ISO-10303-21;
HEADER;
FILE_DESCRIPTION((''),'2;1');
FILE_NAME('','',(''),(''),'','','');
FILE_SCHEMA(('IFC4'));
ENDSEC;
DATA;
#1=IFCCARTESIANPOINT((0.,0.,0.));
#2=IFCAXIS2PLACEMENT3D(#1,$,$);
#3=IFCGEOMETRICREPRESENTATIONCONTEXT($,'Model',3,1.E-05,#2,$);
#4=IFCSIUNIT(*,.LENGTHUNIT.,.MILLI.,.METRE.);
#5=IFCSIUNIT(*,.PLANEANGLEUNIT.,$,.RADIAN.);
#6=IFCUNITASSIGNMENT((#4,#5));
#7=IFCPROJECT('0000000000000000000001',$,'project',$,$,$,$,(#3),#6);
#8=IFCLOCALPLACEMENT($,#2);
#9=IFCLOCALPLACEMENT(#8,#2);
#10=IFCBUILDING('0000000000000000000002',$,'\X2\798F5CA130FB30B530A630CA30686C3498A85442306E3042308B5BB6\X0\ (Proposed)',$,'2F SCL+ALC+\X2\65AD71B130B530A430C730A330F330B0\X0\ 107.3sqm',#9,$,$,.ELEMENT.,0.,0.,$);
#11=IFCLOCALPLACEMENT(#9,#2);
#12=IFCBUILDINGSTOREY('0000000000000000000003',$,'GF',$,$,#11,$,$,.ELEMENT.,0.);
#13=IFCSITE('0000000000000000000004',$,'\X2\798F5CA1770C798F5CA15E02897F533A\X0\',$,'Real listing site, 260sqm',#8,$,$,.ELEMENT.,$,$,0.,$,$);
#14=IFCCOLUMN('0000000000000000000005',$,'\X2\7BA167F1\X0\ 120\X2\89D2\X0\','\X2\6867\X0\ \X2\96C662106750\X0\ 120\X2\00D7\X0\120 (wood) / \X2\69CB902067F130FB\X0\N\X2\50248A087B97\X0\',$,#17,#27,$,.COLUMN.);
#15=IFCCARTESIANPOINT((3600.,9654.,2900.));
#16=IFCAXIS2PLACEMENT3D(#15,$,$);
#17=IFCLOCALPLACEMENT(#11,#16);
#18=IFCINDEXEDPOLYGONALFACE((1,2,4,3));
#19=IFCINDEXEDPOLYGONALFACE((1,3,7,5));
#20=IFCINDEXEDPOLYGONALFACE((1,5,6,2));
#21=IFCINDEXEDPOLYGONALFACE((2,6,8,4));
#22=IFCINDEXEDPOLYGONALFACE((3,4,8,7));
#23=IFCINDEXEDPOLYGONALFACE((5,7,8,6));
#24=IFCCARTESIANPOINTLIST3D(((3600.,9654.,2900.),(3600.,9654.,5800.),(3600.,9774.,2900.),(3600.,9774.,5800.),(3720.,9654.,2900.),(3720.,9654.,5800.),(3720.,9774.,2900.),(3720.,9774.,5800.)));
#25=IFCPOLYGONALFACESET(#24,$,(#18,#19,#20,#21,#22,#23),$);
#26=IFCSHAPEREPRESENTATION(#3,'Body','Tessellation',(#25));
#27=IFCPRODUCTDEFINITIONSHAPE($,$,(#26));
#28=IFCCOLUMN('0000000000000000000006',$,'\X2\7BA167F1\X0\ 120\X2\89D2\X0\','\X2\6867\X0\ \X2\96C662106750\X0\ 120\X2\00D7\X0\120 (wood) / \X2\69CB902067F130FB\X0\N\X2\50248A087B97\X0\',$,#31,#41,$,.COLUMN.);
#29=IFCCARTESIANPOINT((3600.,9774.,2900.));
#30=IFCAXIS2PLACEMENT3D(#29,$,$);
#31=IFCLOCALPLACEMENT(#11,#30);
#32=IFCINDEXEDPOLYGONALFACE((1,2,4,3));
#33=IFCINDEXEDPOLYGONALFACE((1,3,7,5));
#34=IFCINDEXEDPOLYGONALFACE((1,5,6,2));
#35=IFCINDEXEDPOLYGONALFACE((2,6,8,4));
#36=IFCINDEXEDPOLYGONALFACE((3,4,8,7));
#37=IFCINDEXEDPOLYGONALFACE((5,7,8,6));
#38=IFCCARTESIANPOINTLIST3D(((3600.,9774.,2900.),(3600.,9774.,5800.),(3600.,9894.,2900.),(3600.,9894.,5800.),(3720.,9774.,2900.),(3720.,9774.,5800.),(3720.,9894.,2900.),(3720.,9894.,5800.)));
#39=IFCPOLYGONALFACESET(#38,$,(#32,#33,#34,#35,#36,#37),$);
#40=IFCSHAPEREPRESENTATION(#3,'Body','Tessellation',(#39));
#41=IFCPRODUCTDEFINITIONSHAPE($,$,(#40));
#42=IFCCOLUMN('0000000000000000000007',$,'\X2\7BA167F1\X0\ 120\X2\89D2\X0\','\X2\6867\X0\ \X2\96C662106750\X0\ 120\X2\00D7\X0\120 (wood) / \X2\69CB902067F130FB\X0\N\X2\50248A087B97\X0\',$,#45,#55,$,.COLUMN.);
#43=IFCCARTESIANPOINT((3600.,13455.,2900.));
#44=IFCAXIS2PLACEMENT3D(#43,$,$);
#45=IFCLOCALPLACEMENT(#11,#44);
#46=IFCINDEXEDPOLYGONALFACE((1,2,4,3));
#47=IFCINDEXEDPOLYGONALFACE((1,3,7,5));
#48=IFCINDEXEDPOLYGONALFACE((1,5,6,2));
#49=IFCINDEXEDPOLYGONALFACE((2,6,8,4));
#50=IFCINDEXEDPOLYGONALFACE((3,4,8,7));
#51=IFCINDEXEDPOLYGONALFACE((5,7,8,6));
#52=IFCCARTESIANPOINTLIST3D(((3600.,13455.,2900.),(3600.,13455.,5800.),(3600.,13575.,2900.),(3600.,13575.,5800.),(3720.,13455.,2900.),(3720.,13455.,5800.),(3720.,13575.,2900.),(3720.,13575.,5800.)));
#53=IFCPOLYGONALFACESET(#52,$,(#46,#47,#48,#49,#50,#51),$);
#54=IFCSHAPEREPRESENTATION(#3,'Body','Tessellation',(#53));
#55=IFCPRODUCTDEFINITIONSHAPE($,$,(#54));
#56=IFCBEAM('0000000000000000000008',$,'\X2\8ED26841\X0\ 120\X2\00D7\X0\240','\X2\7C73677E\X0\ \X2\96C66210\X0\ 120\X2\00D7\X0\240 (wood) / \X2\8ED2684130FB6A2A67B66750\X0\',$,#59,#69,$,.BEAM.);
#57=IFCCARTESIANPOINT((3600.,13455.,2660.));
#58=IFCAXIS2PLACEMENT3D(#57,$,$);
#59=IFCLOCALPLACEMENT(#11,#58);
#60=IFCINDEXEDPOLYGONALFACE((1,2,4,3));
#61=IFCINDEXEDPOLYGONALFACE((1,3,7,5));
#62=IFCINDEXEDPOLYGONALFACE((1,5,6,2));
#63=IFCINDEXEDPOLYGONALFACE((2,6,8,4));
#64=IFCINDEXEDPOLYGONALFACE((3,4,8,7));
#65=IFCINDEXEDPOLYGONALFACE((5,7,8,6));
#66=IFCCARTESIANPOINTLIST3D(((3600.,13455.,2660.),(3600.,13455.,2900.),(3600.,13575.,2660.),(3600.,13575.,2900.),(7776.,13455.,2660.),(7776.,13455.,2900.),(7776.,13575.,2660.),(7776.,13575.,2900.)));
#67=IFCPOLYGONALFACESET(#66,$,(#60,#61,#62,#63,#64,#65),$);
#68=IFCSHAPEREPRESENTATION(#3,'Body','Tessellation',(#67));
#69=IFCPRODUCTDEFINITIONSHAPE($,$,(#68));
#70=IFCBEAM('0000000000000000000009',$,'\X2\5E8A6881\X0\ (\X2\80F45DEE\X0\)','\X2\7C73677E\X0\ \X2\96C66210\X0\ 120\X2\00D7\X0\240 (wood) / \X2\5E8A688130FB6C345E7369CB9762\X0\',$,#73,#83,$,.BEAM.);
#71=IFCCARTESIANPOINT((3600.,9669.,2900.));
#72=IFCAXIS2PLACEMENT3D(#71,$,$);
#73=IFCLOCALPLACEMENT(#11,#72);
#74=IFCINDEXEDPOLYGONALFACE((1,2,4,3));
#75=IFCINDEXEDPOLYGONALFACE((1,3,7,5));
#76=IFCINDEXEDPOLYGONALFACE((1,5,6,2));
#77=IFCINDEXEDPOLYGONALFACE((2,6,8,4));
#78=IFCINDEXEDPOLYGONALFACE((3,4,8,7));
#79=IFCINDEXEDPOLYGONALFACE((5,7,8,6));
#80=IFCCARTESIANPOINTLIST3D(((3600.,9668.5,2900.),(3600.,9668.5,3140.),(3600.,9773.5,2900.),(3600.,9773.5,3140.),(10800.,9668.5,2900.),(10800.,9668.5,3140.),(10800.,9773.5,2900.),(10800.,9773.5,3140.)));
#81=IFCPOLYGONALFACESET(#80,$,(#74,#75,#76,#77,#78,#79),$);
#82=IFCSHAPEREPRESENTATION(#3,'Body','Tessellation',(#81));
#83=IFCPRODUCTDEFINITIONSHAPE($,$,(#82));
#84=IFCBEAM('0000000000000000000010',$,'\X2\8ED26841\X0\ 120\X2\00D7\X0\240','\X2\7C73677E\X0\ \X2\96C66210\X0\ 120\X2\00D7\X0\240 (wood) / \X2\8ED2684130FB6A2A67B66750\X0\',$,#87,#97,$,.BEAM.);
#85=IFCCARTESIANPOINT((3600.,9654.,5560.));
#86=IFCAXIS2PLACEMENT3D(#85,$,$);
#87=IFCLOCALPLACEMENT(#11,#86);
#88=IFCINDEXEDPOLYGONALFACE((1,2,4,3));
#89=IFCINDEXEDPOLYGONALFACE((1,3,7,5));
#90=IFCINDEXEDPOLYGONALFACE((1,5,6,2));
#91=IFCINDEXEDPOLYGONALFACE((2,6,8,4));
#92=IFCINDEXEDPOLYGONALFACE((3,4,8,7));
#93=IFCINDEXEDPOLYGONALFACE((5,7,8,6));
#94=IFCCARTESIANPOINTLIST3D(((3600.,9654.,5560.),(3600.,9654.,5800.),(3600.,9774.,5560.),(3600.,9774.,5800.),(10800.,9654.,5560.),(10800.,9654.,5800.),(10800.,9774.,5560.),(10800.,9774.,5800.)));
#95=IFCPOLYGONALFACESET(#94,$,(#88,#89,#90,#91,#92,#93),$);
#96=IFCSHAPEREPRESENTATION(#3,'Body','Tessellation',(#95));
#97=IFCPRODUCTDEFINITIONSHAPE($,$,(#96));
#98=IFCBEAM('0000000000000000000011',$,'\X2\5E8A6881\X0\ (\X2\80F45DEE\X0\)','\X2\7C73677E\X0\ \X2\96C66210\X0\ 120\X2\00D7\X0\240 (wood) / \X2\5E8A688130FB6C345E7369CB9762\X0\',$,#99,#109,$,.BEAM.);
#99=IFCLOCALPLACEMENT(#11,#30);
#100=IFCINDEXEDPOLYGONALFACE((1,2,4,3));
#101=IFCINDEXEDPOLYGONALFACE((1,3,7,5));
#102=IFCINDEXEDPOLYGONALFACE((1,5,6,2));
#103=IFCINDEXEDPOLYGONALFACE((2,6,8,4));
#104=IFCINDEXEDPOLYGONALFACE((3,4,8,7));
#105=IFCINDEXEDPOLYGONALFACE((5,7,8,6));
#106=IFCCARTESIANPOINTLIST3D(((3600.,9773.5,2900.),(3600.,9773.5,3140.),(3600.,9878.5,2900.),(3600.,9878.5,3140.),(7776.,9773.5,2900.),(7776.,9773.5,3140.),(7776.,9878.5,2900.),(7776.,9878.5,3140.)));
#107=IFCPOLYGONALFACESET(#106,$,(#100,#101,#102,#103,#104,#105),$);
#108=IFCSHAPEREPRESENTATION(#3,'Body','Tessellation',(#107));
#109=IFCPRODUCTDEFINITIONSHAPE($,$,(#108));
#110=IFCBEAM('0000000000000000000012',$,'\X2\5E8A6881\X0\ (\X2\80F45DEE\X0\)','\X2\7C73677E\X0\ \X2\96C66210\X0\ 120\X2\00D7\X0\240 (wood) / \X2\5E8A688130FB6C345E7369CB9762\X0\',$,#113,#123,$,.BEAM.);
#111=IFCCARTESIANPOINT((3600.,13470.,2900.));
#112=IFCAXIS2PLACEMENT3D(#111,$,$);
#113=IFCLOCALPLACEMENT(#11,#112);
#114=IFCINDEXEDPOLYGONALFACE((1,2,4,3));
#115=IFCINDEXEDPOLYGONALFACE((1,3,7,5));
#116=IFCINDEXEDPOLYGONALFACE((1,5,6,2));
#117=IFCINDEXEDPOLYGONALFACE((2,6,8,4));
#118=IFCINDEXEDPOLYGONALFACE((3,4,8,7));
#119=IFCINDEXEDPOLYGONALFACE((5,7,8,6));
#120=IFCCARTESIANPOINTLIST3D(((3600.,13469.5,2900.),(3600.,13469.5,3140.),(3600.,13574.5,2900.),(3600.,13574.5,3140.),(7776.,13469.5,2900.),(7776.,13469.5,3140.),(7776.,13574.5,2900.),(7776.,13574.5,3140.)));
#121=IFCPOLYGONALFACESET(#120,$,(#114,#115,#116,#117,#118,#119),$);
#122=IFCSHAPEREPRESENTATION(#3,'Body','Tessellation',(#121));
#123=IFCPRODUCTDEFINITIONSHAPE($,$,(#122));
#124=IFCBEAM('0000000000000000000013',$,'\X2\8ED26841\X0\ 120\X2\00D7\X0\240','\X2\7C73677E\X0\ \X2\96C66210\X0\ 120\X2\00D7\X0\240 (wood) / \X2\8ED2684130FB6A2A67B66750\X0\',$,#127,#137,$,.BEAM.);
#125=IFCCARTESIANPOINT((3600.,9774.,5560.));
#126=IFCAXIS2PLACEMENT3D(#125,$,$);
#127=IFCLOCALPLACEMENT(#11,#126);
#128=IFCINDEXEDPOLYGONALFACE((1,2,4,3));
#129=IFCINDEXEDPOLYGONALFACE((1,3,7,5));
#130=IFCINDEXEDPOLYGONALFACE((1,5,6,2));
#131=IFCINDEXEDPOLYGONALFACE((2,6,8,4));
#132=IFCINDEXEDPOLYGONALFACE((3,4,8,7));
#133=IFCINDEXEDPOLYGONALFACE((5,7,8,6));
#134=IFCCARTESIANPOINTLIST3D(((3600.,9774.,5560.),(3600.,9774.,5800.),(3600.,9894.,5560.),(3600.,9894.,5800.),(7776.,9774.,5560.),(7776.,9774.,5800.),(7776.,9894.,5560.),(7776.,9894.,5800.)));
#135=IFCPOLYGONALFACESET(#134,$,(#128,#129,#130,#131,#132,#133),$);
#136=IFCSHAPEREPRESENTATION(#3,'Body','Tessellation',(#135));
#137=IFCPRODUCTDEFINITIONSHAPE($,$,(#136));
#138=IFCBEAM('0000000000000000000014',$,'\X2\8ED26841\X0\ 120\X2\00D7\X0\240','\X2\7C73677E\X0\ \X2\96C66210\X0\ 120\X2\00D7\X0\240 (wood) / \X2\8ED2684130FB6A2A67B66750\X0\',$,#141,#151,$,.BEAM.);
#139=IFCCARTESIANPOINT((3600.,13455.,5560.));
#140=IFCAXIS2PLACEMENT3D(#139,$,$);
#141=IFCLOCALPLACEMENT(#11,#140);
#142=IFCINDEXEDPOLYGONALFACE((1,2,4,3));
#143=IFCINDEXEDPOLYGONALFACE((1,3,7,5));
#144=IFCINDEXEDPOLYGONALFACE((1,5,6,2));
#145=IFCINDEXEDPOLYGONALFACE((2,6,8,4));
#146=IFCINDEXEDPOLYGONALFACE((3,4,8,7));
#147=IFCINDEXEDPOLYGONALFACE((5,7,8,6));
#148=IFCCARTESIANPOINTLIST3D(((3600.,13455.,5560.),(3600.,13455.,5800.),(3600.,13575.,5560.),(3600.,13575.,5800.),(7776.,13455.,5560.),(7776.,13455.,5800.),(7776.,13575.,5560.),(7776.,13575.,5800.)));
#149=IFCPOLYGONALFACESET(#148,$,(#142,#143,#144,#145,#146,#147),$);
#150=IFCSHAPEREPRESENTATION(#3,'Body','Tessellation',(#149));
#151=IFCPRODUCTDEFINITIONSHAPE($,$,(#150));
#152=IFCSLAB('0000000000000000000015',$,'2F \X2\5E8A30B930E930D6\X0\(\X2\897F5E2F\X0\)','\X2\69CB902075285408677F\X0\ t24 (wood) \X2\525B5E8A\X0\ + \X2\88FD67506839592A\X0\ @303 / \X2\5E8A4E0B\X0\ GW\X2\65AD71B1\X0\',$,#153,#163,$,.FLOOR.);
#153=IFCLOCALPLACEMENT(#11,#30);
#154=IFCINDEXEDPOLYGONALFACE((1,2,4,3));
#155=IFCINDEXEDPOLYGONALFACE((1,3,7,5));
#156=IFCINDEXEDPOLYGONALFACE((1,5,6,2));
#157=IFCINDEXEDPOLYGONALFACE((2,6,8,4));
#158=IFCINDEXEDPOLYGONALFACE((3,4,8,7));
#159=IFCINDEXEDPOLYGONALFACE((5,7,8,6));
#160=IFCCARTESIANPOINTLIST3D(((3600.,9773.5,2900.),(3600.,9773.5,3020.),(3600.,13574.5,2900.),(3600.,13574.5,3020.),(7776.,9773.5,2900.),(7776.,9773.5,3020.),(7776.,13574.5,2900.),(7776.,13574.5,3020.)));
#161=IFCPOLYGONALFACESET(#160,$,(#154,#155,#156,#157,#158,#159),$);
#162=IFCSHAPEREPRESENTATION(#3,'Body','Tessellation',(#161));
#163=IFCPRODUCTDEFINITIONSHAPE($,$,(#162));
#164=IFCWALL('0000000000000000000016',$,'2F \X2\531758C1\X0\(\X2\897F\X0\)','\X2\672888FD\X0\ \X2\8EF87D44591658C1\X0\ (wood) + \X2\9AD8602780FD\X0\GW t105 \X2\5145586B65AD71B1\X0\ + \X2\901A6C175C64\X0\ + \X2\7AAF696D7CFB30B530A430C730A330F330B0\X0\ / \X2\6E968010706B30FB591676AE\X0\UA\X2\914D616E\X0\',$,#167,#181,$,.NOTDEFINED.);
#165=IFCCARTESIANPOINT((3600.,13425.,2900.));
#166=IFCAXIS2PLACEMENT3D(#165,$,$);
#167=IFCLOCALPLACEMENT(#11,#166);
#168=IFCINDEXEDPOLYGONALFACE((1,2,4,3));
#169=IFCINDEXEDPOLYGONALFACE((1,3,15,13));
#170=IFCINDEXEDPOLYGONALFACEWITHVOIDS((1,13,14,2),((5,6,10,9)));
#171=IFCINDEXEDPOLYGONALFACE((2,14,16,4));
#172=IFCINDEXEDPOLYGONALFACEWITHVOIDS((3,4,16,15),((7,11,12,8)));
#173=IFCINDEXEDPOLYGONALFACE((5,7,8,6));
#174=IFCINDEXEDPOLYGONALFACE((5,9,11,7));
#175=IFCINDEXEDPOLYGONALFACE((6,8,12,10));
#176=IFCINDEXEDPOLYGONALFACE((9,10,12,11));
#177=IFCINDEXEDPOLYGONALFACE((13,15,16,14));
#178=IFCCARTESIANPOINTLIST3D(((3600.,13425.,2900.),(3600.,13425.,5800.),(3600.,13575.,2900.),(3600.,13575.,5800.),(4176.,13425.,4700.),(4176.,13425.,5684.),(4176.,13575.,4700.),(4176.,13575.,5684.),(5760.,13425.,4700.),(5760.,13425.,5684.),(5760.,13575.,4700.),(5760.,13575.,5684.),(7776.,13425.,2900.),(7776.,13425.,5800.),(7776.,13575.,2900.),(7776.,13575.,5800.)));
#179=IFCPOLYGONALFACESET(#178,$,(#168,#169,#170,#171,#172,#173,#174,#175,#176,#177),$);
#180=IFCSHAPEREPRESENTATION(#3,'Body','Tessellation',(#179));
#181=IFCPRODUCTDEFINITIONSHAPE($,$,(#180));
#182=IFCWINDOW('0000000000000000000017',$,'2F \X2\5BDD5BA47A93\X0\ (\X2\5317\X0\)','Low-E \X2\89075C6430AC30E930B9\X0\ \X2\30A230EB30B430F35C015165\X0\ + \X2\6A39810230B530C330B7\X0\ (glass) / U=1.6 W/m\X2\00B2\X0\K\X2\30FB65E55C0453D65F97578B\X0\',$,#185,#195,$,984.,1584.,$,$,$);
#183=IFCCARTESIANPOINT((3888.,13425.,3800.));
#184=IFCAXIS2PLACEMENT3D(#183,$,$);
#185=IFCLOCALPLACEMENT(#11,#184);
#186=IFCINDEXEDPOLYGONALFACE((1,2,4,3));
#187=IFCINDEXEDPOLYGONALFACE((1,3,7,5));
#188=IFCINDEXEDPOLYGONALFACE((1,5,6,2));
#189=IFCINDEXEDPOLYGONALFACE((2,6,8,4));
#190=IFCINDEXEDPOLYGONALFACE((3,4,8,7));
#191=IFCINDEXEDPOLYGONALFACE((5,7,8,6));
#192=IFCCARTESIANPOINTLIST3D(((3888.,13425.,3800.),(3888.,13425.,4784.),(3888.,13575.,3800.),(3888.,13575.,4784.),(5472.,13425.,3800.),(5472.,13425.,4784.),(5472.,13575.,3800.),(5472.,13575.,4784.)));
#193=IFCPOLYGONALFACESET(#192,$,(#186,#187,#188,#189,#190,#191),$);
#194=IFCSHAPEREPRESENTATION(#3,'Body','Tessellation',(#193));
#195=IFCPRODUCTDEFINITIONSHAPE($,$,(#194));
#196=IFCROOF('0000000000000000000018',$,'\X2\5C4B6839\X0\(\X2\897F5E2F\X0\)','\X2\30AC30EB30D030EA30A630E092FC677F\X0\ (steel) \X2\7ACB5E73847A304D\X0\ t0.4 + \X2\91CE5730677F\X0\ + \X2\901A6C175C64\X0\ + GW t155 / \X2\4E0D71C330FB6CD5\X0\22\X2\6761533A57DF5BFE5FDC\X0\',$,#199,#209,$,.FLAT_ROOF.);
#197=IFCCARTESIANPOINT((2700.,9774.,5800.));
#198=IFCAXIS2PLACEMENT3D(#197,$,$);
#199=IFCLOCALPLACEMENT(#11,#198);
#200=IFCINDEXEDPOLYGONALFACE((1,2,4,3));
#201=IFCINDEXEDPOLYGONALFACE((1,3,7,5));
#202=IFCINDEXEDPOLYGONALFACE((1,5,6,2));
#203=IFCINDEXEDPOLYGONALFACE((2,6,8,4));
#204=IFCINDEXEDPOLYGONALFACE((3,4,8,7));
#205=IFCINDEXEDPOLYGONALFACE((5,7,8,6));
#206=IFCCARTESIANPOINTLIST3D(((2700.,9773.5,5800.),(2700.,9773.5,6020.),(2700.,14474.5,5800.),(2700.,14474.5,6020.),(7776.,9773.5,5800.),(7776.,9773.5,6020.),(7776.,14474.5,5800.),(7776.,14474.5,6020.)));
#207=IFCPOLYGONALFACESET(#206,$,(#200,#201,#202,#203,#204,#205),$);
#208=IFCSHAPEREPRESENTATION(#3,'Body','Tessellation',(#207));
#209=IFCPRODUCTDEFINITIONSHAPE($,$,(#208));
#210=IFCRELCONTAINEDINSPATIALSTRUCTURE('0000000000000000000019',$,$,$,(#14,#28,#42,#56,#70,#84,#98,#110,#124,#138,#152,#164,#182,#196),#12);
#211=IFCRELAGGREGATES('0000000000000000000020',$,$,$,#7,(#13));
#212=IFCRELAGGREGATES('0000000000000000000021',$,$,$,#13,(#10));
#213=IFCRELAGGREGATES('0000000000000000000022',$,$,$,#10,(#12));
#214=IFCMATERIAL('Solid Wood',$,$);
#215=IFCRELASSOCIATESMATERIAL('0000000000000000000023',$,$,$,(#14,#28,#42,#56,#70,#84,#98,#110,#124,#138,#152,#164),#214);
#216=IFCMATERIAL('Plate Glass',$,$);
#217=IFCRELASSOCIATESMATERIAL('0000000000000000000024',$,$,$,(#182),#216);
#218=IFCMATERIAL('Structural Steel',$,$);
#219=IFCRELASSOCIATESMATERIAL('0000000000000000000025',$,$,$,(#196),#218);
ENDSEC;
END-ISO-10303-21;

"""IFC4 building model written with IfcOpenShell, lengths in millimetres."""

from ifc_helpers import new_model, si_unit, frame, frame_2d, origin, place, context, project, spatial, rectangle, extrude, material, element, fill, save


model = new_model("IFC4")

# Units and contexts
model_context = context("Model", 3, precision=1e-05, world=origin())
ifc_project = project(units=[si_unit("LENGTHUNIT", "METRE", prefix="MILLI"), si_unit("PLANEANGLEUNIT", "RADIAN")], contexts=[model_context])

# Site, building, storey
site_placement = place(None, origin())
site = spatial("IfcSite", under=ifc_project, at=site_placement, Name="福岡県福岡市西区", ObjectType="Real listing site, 260sqm", CompositionType="ELEMENT", RefElevation=0.0)
building_placement = place(site_placement, origin())
building = spatial("IfcBuilding", under=site, at=building_placement, Name="福岡・サウナと水風呂のある家 (Proposed)", ObjectType="2F SCL+ALC+断熱サイディング 107.3sqm", CompositionType="ELEMENT", ElevationOfRefHeight=0.0, ElevationOfTerrain=0.0)
storey_placement = place(building_placement, origin())
storey = spatial("IfcBuildingStorey", under=building, at=storey_placement, Name="GF", CompositionType="ELEMENT", Elevation=0.0)

# Columns
ifc_material_1 = material(Name="Solid Wood")
column_1_placement = place(storey_placement, frame((3600.0, 9654.0, 2900.0)))
element("IfcColumn", 1, at=column_1_placement, inside=storey, material=ifc_material_1, Name="管柱 120角", Description="桧 集成材 120×120 (wood) / 構造柱・N値計算", PredefinedType="COLUMN", context=model_context, shape_type="SweptSolid", body=[
    extrude(rectangle(XDim=120.0, YDim=120.0, at=frame_2d((60.0, 60.0))), frame((3600.0, 9654.0, 2900.0)), (0.0, 0.0, 1.0), 2900.0),
])
column_2_placement = place(storey_placement, frame((3600.0, 9774.0, 2900.0)))
element("IfcColumn", 2, at=column_2_placement, inside=storey, material=ifc_material_1, Name="管柱 120角", Description="桧 集成材 120×120 (wood) / 構造柱・N値計算", PredefinedType="COLUMN", context=model_context, shape_type="SweptSolid", body=[
    extrude(rectangle(XDim=120.0, YDim=120.0, at=frame_2d((60.0, 60.0))), frame((3600.0, 9774.0, 2900.0)), (0.0, 0.0, 1.0), 2900.0),
])
column_3_placement = place(storey_placement, frame((3600.0, 13455.0, 2900.0)))
element("IfcColumn", 3, at=column_3_placement, inside=storey, material=ifc_material_1, Name="管柱 120角", Description="桧 集成材 120×120 (wood) / 構造柱・N値計算", PredefinedType="COLUMN", context=model_context, shape_type="SweptSolid", body=[
    extrude(rectangle(XDim=120.0, YDim=120.0, at=frame_2d((60.0, 60.0))), frame((3600.0, 13455.0, 2900.0)), (0.0, 0.0, 1.0), 2900.0),
])

# Beams
beam_1_placement = place(storey_placement, frame((3600.0, 13455.0, 2660.0)))
element("IfcBeam", 4, at=beam_1_placement, inside=storey, material=ifc_material_1, Name="軒桁 120×240", Description="米松 集成 120×240 (wood) / 軒桁・横架材", PredefinedType="BEAM", context=model_context, shape_type="SweptSolid", body=[
    extrude(rectangle(XDim=4176.0, YDim=120.0, at=frame_2d((2088.0, 60.0))), frame((3600.0, 13455.0, 2660.0)), (0.0, 0.0, 1.0), 240.0),
])
beam_2_placement = place(storey_placement, frame((3600.0, 9669.0, 2900.0)))
element("IfcBeam", 5, at=beam_2_placement, inside=storey, material=ifc_material_1, Name="床梁 (胴差)", Description="米松 集成 120×240 (wood) / 床梁・水平構面", PredefinedType="BEAM", context=model_context, shape_type="SweptSolid", body=[
    extrude(rectangle(XDim=7200.0, YDim=105.0, at=frame_2d((3600.0, 52.0))), frame((3600.0, 9669.0, 2900.0)), (0.0, 0.0, 1.0), 240.0),
])
beam_3_placement = place(storey_placement, frame((3600.0, 9654.0, 5560.0)))
element("IfcBeam", 6, at=beam_3_placement, inside=storey, material=ifc_material_1, Name="軒桁 120×240", Description="米松 集成 120×240 (wood) / 軒桁・横架材", PredefinedType="BEAM", context=model_context, shape_type="SweptSolid", body=[
    extrude(rectangle(XDim=7200.0, YDim=120.0, at=frame_2d((3600.0, 60.0))), frame((3600.0, 9654.0, 5560.0)), (0.0, 0.0, 1.0), 240.0),
])
beam_4_placement = place(storey_placement, frame((3600.0, 9774.0, 2900.0)))
element("IfcBeam", 7, at=beam_4_placement, inside=storey, material=ifc_material_1, Name="床梁 (胴差)", Description="米松 集成 120×240 (wood) / 床梁・水平構面", PredefinedType="BEAM", context=model_context, shape_type="SweptSolid", body=[
    extrude(rectangle(XDim=4176.0, YDim=105.0, at=frame_2d((2088.0, 52.0))), frame((3600.0, 9774.0, 2900.0)), (0.0, 0.0, 1.0), 240.0),
])
beam_5_placement = place(storey_placement, frame((3600.0, 13470.0, 2900.0)))
element("IfcBeam", 8, at=beam_5_placement, inside=storey, material=ifc_material_1, Name="床梁 (胴差)", Description="米松 集成 120×240 (wood) / 床梁・水平構面", PredefinedType="BEAM", context=model_context, shape_type="SweptSolid", body=[
    extrude(rectangle(XDim=4176.0, YDim=105.0, at=frame_2d((2088.0, 52.0))), frame((3600.0, 13470.0, 2900.0)), (0.0, 0.0, 1.0), 240.0),
])
beam_6_placement = place(storey_placement, frame((3600.0, 9774.0, 5560.0)))
element("IfcBeam", 9, at=beam_6_placement, inside=storey, material=ifc_material_1, Name="軒桁 120×240", Description="米松 集成 120×240 (wood) / 軒桁・横架材", PredefinedType="BEAM", context=model_context, shape_type="SweptSolid", body=[
    extrude(rectangle(XDim=4176.0, YDim=120.0, at=frame_2d((2088.0, 60.0))), frame((3600.0, 9774.0, 5560.0)), (0.0, 0.0, 1.0), 240.0),
])
beam_7_placement = place(storey_placement, frame((3600.0, 13455.0, 5560.0)))
element("IfcBeam", 10, at=beam_7_placement, inside=storey, material=ifc_material_1, Name="軒桁 120×240", Description="米松 集成 120×240 (wood) / 軒桁・横架材", PredefinedType="BEAM", context=model_context, shape_type="SweptSolid", body=[
    extrude(rectangle(XDim=4176.0, YDim=120.0, at=frame_2d((2088.0, 60.0))), frame((3600.0, 13455.0, 5560.0)), (0.0, 0.0, 1.0), 240.0),
])

# Slab
slab_placement = place(storey_placement, frame((3600.0, 9774.0, 2900.0)))
element("IfcSlab", 11, at=slab_placement, inside=storey, material=ifc_material_1, Name="2F 床スラブ(西帯)", Description="構造用合板 t24 (wood) 剛床 + 製材根太 @303 / 床下 GW断熱", PredefinedType="FLOOR", context=model_context, shape_type="SweptSolid", body=[
    extrude(rectangle(XDim=4176.0, YDim=3801.0, at=frame_2d((2088.0, 1900.0))), frame((3600.0, 9774.0, 2900.0)), (0.0, 0.0, 1.0), 120.0),
])

# Wall, opening, window
wall_1_placement = place(storey_placement, frame((3600.0, 13425.0, 2900.0)))
wall_1 = element("IfcWall", 12, at=wall_1_placement, inside=storey, material=ifc_material_1, Name="2F 北壁(西)", Description="木製 軸組外壁 (wood) + 高性能GW t105 充填断熱 + 通気層 + 窯業系サイディング / 準耐火・外皮UA配慮", PredefinedType="NOTDEFINED", context=model_context, shape_type="SweptSolid", body=[
    extrude(rectangle(XDim=4176.0, YDim=150.0, at=frame_2d((2088.0, 75.0))), frame((3600.0, 13425.0, 2900.0)), (0.0, 0.0, 1.0), 2900.0),
])
opening_placement = place(storey_placement, frame((3888.0, 13425.0, 3800.0)))
opening = element("IfcOpeningElement", 13, at=opening_placement, cuts=wall_1, PredefinedType="NOTDEFINED", context=model_context, shape_type="SweptSolid", body=[
    extrude(rectangle(XDim=1584.0, YDim=150.0, at=frame_2d((792.0, 75.0))), frame((3888.0, 13425.0, 3800.0)), (0.0, 0.0, 1.0), 984.0),
])
ifc_material_2 = material(Name="Plate Glass")
window_placement = place(storey_placement, frame((3888.0, 13425.0, 3800.0)))
window = element("IfcWindow", 14, at=window_placement, inside=storey, material=ifc_material_2, Name="2F 寝室窓 (北)", Description="Low-E 複層ガラス アルゴン封入 + 樹脂サッシ (glass) / U=1.6 W/m²K・日射取得型", OverallHeight=984.0, OverallWidth=1584.0, context=model_context, shape_type="SweptSolid", body=[
    extrude(rectangle(XDim=1584.0, YDim=150.0, at=frame_2d((792.0, 75.0))), frame((3888.0, 13425.0, 3800.0)), (0.0, 0.0, 1.0), 984.0),
])
fill(opening, window)

# Roof
ifc_material_3 = material(Name="Structural Steel")
for number, where, name in (
    (15, (2700.0, 9774.0, 5800.0), "屋根(西帯)"),
):
    element("IfcRoof", number, at=place(storey_placement, frame(where)), inside=storey, material=ifc_material_3, Name=name, Description="ガルバリウム鋼板 (steel) 立平葺き t0.4 + 野地板 + 通気層 + GW t155 / 不燃・法22条区域対応", PredefinedType="FLAT_ROOF", context=model_context, shape_type="SweptSolid", body=[
        extrude(rectangle(XDim=5076.0, YDim=4701.0, at=frame_2d((2538.0, 2350.0))), frame((2700.0, 9774.0, 5800.0)), (0.0, 0.0, 1.0), 220.0),
    ])

save(model, "model.ifc")
